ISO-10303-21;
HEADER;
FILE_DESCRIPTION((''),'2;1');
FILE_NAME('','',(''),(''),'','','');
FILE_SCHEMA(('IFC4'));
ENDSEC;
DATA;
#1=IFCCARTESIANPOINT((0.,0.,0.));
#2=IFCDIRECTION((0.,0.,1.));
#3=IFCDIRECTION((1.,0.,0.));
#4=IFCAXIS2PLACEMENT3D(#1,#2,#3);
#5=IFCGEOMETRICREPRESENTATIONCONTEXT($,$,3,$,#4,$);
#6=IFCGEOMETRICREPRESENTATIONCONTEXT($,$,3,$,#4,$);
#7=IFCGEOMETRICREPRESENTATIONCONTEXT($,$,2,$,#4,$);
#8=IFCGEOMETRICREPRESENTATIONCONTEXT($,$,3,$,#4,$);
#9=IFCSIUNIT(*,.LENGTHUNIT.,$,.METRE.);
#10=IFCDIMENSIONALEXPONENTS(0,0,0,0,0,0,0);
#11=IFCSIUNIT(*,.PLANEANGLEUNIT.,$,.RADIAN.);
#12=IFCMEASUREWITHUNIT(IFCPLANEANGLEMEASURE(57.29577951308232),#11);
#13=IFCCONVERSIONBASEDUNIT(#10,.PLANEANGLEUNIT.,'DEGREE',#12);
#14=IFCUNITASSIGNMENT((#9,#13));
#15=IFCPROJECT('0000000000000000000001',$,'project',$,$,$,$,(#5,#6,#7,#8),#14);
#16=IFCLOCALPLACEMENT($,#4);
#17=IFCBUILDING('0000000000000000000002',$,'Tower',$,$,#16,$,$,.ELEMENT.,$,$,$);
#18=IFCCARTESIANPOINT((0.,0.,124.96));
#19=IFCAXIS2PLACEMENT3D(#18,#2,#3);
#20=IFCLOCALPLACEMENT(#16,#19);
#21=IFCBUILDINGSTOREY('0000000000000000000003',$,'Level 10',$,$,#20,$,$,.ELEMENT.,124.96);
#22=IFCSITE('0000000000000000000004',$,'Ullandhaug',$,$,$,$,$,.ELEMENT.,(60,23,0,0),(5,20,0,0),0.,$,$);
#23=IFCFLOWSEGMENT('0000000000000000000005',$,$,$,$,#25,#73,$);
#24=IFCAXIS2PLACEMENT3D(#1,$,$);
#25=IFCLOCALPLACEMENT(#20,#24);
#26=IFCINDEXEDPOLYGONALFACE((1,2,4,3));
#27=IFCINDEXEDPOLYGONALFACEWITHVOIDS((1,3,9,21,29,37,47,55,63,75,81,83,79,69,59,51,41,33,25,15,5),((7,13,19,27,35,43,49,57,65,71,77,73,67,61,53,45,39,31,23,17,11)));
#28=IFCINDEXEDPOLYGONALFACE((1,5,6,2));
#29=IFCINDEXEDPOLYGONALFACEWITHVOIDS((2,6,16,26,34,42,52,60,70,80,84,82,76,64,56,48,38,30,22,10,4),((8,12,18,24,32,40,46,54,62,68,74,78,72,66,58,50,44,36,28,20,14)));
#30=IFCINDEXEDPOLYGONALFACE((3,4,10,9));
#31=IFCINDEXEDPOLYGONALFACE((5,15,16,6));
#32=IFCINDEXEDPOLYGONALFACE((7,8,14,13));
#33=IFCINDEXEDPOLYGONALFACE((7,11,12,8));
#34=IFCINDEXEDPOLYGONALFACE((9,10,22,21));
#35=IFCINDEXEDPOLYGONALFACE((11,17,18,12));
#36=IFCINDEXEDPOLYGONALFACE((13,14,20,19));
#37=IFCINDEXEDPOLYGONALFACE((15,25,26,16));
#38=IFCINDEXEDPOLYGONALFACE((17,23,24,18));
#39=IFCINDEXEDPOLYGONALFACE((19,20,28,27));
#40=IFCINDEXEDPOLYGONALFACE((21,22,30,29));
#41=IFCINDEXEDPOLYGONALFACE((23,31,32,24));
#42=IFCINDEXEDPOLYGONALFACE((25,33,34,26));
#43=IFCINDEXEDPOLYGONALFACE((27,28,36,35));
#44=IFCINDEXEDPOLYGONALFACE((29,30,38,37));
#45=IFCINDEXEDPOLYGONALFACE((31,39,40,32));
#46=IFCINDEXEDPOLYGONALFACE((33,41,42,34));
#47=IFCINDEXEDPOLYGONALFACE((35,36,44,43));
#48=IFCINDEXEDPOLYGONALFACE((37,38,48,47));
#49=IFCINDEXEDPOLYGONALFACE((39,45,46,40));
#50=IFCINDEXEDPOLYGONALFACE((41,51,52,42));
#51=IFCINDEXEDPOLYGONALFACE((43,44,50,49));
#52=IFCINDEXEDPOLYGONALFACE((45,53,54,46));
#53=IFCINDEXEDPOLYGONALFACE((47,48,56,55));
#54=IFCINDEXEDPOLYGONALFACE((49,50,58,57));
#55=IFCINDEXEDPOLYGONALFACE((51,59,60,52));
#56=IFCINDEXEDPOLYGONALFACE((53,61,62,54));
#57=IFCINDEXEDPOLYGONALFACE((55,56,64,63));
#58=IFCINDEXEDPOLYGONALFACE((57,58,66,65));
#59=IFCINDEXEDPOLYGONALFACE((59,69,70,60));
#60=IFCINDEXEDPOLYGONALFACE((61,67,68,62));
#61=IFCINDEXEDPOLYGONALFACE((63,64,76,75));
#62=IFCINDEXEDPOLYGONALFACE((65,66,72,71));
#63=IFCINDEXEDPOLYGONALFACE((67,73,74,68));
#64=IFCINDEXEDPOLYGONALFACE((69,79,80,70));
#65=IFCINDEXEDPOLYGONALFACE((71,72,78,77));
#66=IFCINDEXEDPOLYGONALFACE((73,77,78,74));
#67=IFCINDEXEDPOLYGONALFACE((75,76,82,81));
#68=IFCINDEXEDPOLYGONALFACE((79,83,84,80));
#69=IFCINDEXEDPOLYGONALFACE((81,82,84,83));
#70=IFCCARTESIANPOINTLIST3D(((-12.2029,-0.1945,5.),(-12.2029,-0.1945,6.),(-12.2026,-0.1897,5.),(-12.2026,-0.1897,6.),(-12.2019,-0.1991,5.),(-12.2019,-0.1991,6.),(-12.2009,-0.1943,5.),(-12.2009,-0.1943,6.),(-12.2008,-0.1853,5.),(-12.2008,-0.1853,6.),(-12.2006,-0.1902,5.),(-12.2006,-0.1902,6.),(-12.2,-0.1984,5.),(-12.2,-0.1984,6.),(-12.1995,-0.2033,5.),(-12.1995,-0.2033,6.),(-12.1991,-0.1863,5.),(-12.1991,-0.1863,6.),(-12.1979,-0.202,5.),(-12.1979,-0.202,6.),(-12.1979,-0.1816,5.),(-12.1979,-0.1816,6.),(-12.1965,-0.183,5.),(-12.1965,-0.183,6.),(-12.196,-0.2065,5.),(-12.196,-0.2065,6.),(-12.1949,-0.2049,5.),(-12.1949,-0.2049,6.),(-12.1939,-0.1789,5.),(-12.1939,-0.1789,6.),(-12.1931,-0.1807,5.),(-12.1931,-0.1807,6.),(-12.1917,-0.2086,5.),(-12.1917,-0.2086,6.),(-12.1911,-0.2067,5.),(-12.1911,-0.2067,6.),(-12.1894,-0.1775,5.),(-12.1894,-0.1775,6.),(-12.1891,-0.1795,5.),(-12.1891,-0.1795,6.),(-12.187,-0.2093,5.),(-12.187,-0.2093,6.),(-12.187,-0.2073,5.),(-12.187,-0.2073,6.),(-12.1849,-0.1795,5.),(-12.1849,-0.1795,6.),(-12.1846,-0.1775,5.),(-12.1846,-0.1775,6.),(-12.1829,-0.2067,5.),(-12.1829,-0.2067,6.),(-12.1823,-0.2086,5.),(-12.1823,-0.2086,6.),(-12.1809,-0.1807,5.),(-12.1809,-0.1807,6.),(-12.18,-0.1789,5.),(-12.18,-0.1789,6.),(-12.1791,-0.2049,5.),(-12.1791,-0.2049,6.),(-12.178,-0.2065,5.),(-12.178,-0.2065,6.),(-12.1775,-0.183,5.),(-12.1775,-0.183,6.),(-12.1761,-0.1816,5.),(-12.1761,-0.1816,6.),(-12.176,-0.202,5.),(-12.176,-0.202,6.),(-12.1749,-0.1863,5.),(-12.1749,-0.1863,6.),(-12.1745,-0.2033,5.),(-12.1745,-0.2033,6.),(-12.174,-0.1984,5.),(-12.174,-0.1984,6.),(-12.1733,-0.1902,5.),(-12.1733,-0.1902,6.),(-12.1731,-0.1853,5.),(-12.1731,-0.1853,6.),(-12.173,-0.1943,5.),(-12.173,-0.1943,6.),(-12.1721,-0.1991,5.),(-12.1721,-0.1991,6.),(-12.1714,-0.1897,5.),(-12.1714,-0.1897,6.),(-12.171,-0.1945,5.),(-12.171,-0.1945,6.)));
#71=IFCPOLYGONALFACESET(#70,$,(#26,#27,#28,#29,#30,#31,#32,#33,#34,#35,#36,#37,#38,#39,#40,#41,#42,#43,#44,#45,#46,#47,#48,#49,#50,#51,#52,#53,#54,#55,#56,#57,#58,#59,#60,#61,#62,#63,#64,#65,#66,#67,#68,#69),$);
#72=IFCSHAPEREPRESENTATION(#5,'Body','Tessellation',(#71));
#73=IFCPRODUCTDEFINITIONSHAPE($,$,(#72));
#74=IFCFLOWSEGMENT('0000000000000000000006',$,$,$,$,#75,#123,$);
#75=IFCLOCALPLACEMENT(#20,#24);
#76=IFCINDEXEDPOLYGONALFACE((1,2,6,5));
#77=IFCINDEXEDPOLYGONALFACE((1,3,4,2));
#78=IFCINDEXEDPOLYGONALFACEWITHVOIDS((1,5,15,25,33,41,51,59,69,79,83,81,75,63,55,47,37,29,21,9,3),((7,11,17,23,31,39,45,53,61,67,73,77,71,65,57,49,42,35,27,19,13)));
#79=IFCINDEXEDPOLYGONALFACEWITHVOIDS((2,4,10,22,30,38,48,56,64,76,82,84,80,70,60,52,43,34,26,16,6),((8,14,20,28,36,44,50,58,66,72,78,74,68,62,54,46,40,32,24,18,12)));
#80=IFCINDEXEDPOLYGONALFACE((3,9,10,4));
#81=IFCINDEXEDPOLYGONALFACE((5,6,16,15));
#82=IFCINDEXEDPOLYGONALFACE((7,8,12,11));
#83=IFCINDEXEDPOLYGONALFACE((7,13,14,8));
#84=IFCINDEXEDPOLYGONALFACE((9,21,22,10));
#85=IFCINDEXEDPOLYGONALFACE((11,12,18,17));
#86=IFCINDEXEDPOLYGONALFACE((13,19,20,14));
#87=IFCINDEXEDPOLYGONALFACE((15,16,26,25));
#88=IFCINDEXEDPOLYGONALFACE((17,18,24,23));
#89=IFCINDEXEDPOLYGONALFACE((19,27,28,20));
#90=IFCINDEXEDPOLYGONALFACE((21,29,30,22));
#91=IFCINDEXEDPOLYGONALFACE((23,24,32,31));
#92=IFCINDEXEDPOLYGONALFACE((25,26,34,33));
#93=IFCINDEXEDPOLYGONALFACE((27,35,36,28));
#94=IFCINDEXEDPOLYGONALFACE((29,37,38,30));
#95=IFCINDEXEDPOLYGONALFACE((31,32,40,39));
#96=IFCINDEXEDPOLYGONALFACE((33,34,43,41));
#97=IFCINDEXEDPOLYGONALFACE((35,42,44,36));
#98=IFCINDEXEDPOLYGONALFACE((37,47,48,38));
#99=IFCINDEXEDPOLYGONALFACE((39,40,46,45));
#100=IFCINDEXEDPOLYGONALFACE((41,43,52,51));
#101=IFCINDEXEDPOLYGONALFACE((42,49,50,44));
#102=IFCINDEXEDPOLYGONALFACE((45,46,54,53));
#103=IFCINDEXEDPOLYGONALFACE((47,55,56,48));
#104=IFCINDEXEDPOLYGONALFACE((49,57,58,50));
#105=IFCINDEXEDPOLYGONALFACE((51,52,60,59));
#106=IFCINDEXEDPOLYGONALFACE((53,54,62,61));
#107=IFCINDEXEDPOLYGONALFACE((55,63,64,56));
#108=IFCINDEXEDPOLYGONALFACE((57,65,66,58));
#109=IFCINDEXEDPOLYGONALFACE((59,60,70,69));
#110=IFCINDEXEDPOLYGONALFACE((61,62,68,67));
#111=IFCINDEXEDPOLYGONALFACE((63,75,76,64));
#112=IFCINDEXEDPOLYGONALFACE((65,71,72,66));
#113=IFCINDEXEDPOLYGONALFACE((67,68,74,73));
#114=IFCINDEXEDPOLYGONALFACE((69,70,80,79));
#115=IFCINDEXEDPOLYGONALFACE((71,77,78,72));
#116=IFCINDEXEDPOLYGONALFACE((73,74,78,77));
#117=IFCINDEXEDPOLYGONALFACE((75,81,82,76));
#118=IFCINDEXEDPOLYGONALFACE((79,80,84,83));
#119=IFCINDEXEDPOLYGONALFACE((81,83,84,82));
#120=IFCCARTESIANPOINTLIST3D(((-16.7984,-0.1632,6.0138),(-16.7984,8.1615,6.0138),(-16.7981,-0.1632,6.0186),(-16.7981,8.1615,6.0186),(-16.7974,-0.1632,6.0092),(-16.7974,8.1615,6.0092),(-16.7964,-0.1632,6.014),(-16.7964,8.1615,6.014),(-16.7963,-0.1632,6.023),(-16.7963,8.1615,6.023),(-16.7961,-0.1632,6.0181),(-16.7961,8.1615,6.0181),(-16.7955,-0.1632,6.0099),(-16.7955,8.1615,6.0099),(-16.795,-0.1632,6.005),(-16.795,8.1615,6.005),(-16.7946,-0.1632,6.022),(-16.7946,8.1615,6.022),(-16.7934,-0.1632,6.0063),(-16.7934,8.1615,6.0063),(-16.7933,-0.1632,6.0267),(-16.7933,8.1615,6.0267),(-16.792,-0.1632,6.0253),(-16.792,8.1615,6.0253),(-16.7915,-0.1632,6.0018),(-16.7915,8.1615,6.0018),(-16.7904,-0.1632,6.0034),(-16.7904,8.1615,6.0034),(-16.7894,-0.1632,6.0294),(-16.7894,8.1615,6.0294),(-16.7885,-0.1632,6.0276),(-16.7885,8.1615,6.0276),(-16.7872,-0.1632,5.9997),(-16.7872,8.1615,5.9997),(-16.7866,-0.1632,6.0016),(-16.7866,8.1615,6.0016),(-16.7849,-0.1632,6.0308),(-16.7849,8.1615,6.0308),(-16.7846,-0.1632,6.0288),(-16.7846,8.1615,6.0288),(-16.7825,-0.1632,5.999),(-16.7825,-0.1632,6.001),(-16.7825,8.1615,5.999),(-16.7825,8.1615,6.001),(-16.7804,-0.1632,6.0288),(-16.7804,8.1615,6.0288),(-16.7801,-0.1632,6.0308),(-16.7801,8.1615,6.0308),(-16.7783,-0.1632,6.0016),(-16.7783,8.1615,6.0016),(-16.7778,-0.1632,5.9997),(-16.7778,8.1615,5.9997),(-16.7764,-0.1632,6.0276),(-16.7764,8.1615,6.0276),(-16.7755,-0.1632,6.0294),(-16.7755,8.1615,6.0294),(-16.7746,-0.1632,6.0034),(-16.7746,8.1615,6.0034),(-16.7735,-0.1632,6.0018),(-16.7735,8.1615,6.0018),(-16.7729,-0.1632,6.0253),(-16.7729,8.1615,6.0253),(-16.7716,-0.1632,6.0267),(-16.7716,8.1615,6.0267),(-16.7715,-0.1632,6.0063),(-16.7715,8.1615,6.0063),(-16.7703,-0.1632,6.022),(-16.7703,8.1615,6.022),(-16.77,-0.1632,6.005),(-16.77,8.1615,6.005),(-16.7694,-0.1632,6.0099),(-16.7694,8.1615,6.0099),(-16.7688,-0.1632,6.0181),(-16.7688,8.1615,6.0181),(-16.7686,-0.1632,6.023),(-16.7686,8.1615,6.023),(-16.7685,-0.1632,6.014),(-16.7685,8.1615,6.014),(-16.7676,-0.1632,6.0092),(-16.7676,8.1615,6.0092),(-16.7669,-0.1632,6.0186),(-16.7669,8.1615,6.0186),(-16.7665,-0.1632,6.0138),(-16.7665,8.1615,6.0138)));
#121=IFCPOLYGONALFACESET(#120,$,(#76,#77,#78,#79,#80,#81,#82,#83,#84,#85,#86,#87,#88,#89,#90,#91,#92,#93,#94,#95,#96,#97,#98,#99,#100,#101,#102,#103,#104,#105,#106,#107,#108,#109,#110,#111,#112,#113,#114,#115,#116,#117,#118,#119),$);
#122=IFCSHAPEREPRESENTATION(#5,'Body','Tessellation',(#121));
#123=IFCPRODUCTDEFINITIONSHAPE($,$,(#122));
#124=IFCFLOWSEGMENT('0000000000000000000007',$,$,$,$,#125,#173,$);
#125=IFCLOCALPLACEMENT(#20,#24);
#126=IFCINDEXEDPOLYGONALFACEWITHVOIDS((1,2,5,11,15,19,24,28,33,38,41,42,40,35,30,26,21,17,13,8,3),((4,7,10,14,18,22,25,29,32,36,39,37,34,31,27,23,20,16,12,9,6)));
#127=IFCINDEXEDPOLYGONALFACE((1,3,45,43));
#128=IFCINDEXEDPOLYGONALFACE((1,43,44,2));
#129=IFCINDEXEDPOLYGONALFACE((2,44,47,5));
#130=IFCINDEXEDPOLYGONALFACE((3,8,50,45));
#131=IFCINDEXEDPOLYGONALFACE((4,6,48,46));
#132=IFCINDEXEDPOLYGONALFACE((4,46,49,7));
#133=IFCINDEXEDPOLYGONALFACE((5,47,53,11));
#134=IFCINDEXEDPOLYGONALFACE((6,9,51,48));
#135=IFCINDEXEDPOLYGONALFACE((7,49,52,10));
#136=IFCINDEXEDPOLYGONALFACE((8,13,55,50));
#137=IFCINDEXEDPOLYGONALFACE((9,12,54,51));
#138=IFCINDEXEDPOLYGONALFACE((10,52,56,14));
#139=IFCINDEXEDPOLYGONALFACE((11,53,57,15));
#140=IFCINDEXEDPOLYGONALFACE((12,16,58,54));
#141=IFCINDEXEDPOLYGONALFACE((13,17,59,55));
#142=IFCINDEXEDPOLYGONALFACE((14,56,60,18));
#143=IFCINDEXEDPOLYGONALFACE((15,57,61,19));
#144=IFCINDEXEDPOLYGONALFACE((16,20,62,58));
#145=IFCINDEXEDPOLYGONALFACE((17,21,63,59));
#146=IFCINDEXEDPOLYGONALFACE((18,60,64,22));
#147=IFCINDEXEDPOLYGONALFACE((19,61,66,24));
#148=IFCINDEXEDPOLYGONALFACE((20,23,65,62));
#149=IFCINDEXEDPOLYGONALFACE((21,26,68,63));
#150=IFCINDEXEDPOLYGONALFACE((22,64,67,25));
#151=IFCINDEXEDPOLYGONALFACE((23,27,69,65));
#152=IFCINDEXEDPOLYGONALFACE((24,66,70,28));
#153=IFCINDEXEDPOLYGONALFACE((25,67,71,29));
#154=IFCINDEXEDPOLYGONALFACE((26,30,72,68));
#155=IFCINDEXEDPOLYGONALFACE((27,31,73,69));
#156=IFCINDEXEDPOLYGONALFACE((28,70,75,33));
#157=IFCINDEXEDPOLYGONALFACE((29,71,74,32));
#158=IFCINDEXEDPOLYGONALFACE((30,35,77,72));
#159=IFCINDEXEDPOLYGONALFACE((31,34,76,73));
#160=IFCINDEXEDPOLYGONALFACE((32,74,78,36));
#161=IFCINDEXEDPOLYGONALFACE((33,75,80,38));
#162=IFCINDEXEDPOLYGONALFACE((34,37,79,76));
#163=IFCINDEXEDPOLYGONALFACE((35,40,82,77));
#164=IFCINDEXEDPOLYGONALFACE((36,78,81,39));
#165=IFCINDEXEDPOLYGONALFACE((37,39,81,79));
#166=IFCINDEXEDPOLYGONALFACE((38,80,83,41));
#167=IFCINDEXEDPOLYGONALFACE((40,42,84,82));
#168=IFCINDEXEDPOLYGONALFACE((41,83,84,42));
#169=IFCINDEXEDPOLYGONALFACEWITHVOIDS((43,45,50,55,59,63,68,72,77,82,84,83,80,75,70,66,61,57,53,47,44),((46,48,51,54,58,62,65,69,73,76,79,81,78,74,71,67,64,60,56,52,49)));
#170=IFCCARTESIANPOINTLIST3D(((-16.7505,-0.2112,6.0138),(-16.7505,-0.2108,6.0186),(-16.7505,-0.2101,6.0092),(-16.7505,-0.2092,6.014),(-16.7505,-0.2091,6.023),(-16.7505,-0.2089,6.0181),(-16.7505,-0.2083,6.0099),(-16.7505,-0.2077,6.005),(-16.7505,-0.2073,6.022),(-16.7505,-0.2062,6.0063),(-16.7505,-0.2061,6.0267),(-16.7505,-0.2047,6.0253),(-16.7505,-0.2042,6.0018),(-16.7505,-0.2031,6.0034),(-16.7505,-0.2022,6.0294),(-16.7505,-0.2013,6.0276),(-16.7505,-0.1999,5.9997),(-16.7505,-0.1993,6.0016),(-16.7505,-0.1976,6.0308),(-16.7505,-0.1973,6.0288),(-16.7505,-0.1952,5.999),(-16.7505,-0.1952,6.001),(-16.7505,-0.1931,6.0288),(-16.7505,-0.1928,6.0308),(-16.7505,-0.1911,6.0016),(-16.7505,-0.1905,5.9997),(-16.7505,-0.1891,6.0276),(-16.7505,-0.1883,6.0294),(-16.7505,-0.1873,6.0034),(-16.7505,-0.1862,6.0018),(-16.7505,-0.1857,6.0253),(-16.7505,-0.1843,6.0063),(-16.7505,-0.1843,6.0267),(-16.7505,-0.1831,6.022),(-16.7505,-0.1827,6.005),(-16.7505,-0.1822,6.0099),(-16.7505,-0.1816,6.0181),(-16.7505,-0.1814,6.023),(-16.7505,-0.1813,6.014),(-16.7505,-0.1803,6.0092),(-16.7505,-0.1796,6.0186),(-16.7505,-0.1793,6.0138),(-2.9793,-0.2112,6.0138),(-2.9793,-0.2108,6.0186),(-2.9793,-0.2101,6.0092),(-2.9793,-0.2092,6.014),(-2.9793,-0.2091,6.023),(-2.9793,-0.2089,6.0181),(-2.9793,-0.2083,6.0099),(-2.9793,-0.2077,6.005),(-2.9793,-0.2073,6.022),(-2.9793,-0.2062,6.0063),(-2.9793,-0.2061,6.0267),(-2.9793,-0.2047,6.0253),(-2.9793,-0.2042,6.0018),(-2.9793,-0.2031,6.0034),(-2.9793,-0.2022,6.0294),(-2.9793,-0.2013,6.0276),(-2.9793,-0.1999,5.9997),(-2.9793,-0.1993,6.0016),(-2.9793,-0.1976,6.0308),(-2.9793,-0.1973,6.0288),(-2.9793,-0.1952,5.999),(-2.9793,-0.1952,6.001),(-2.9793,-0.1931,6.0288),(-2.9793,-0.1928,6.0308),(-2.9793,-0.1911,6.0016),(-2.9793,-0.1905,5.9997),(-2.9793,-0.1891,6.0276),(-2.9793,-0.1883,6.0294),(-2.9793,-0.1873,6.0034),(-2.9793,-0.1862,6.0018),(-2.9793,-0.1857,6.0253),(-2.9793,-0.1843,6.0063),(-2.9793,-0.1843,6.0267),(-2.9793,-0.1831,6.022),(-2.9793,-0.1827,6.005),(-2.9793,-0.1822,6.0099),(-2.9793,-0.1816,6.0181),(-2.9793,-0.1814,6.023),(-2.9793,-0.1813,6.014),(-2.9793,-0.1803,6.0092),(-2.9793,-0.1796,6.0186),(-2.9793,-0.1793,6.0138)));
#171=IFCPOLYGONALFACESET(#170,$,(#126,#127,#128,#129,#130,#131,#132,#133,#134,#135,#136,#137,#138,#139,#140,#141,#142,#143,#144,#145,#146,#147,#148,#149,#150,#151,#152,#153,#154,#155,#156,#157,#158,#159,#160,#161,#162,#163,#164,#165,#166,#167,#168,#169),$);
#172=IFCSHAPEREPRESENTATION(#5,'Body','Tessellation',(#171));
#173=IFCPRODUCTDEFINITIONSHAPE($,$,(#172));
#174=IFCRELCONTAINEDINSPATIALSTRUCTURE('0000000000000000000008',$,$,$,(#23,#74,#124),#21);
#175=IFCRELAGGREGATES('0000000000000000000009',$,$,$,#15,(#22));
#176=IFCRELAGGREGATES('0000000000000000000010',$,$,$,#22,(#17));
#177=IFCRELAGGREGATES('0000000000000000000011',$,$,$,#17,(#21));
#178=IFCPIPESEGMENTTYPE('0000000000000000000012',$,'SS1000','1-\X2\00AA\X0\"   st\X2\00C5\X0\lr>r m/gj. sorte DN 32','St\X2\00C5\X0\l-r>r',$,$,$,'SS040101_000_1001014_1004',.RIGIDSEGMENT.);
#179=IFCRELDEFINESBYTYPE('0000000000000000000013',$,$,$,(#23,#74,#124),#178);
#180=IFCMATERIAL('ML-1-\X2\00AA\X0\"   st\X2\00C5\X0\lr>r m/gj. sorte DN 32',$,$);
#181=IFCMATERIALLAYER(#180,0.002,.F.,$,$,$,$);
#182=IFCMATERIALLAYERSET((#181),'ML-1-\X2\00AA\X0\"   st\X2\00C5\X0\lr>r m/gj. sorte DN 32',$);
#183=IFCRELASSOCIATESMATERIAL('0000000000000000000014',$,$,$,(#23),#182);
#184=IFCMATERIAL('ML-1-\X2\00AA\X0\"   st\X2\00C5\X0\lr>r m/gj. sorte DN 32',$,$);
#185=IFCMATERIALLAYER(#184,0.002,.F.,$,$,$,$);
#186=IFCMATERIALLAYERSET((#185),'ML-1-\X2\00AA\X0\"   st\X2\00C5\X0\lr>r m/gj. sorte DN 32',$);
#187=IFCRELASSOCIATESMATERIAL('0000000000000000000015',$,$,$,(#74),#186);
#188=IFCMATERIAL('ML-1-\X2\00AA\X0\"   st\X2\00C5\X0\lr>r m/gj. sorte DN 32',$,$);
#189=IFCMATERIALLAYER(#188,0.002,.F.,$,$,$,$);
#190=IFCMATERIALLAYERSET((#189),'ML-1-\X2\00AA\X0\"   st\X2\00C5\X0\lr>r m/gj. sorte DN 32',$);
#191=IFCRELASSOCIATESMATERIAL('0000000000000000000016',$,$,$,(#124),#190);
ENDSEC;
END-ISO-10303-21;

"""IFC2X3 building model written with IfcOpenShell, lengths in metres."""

from ifc_helpers import new_model, entity, si_unit, converted_unit, frame, origin_with_axes, origin_2d_with_axis, place, context, project, spatial, hollow_circle, extrude, material, layer, layer_set, layer_usage, type_object, element, save


model = new_model("IFC2X3")

# Units and contexts
context_of_model_1 = context(None, 3, world=origin_with_axes())
context_of_model_2 = context(None, 3, world=origin_with_axes())
context_of_model_3 = context(None, 2, world=origin_with_axes())
context_of_model_4 = context(None, 3, world=origin_with_axes())
ifc_project = project(units=[si_unit("LENGTHUNIT", "METRE"), converted_unit("PLANEANGLEUNIT", "DEGREE", entity("IfcPlaneAngleMeasure", 57.29577951308232), si_unit("PLANEANGLEUNIT", "RADIAN"), dimensions=[0, 0, 0, 0, 0, 0, 0])], contexts=[context_of_model_1, context_of_model_2, context_of_model_3, context_of_model_4])

# Site, building, storey
site = spatial("IfcSite", under=ifc_project, Name="Ullandhaug", CompositionType="ELEMENT", RefLatitude=(60, 23, 0, 0), RefLongitude=(5, 20, 0, 0), RefElevation=0.0)
building_placement = place(None, origin_with_axes())
building = spatial("IfcBuilding", under=site, at=building_placement, Name="Tower", CompositionType="ELEMENT")
storey_placement = place(building_placement, frame((0.0, 0.0, 124.96), z_axis=(0.0, 0.0, 1.0), x_axis=(1.0, 0.0, 0.0)))
storey = spatial("IfcBuildingStorey", under=building, at=storey_placement, Name="Level 10", CompositionType="ELEMENT", Elevation=124.96)

# Flow segments
pipe_segment_type_1 = type_object("IfcPipeSegmentType", Name="SS1000", Description="1-ª\"   stÅlr>r m/gj. sorte DN 32", ApplicableOccurrence="StÅl-r>r", ElementType="SS040101_000_1001014_1004", PredefinedType="RIGIDSEGMENT")
ifc_material_1 = material(Name="ML-1-ª\"   stÅlr>r m/gj. sorte DN 32")
ifc_layer_1 = layer(ifc_material_1, 0.002, ventilated=False)
ifc_layer_set_1 = layer_set([ifc_layer_1], Name="ML-1-ª\"   stÅlr>r m/gj. sorte DN 32")
ifc_layer_usage_1 = layer_usage(ifc_layer_set_1, "AXIS2", "POSITIVE", 0.0)
flow_segment_1_placement = place(storey_placement, frame((-12.187, -0.1933, 5.0), z_axis=(0.0, 0.0, 1.0), x_axis=(0.0, -1.0, 0.0)))
element("IfcFlowSegment", 1, at=flow_segment_1_placement, inside=storey, type_object=pipe_segment_type_1, material=ifc_layer_usage_1, context=context_of_model_1, shape_type="SweptSolid", body=[
    extrude(hollow_circle(Radius=0.016, WallThickness=0.002, at=origin_2d_with_axis()), origin_with_axes(), (0.0, 0.0, 1.0), 1.0),
])
ifc_material_2 = material(Name="ML-1-ª\"   stÅlr>r m/gj. sorte DN 32")
ifc_layer_2 = layer(ifc_material_2, 0.002, ventilated=False)
ifc_layer_set_2 = layer_set([ifc_layer_2], Name="ML-1-ª\"   stÅlr>r m/gj. sorte DN 32")
ifc_layer_usage_2 = layer_usage(ifc_layer_set_2, "AXIS2", "POSITIVE", 0.0)
flow_segment_2_placement = place(storey_placement, frame((-16.7825, 8.1615, 6.015), z_axis=(0.0, -1.0, 0.0), x_axis=(0.0, 0.0, -1.0)))
element("IfcFlowSegment", 2, at=flow_segment_2_placement, inside=storey, type_object=pipe_segment_type_1, material=ifc_layer_usage_2, context=context_of_model_1, shape_type="SweptSolid", body=[
    extrude(hollow_circle(Radius=0.016, WallThickness=0.002, at=origin_2d_with_axis()), origin_with_axes(), (0.0, 0.0, 1.0), 8.3247),
])
ifc_material_3 = material(Name="ML-1-ª\"   stÅlr>r m/gj. sorte DN 32")
ifc_layer_3 = layer(ifc_material_3, 0.002, ventilated=False)
ifc_layer_set_3 = layer_set([ifc_layer_3], Name="ML-1-ª\"   stÅlr>r m/gj. sorte DN 32")
ifc_layer_usage_3 = layer_usage(ifc_layer_set_3, "AXIS2", "POSITIVE", 0.0)
flow_segment_3_placement = place(storey_placement, frame((-16.7505, -0.1952, 6.015), z_axis=(1.0, 0.0, 0.0), x_axis=(0.0, 0.0, -1.0)))
element("IfcFlowSegment", 3, at=flow_segment_3_placement, inside=storey, type_object=pipe_segment_type_1, material=ifc_layer_usage_3, context=context_of_model_1, shape_type="SweptSolid", body=[
    extrude(hollow_circle(Radius=0.016, WallThickness=0.002, at=origin_2d_with_axis()), origin_with_axes(), (0.0, 0.0, 1.0), 13.7711),
])

save(model, "model.ifc")
